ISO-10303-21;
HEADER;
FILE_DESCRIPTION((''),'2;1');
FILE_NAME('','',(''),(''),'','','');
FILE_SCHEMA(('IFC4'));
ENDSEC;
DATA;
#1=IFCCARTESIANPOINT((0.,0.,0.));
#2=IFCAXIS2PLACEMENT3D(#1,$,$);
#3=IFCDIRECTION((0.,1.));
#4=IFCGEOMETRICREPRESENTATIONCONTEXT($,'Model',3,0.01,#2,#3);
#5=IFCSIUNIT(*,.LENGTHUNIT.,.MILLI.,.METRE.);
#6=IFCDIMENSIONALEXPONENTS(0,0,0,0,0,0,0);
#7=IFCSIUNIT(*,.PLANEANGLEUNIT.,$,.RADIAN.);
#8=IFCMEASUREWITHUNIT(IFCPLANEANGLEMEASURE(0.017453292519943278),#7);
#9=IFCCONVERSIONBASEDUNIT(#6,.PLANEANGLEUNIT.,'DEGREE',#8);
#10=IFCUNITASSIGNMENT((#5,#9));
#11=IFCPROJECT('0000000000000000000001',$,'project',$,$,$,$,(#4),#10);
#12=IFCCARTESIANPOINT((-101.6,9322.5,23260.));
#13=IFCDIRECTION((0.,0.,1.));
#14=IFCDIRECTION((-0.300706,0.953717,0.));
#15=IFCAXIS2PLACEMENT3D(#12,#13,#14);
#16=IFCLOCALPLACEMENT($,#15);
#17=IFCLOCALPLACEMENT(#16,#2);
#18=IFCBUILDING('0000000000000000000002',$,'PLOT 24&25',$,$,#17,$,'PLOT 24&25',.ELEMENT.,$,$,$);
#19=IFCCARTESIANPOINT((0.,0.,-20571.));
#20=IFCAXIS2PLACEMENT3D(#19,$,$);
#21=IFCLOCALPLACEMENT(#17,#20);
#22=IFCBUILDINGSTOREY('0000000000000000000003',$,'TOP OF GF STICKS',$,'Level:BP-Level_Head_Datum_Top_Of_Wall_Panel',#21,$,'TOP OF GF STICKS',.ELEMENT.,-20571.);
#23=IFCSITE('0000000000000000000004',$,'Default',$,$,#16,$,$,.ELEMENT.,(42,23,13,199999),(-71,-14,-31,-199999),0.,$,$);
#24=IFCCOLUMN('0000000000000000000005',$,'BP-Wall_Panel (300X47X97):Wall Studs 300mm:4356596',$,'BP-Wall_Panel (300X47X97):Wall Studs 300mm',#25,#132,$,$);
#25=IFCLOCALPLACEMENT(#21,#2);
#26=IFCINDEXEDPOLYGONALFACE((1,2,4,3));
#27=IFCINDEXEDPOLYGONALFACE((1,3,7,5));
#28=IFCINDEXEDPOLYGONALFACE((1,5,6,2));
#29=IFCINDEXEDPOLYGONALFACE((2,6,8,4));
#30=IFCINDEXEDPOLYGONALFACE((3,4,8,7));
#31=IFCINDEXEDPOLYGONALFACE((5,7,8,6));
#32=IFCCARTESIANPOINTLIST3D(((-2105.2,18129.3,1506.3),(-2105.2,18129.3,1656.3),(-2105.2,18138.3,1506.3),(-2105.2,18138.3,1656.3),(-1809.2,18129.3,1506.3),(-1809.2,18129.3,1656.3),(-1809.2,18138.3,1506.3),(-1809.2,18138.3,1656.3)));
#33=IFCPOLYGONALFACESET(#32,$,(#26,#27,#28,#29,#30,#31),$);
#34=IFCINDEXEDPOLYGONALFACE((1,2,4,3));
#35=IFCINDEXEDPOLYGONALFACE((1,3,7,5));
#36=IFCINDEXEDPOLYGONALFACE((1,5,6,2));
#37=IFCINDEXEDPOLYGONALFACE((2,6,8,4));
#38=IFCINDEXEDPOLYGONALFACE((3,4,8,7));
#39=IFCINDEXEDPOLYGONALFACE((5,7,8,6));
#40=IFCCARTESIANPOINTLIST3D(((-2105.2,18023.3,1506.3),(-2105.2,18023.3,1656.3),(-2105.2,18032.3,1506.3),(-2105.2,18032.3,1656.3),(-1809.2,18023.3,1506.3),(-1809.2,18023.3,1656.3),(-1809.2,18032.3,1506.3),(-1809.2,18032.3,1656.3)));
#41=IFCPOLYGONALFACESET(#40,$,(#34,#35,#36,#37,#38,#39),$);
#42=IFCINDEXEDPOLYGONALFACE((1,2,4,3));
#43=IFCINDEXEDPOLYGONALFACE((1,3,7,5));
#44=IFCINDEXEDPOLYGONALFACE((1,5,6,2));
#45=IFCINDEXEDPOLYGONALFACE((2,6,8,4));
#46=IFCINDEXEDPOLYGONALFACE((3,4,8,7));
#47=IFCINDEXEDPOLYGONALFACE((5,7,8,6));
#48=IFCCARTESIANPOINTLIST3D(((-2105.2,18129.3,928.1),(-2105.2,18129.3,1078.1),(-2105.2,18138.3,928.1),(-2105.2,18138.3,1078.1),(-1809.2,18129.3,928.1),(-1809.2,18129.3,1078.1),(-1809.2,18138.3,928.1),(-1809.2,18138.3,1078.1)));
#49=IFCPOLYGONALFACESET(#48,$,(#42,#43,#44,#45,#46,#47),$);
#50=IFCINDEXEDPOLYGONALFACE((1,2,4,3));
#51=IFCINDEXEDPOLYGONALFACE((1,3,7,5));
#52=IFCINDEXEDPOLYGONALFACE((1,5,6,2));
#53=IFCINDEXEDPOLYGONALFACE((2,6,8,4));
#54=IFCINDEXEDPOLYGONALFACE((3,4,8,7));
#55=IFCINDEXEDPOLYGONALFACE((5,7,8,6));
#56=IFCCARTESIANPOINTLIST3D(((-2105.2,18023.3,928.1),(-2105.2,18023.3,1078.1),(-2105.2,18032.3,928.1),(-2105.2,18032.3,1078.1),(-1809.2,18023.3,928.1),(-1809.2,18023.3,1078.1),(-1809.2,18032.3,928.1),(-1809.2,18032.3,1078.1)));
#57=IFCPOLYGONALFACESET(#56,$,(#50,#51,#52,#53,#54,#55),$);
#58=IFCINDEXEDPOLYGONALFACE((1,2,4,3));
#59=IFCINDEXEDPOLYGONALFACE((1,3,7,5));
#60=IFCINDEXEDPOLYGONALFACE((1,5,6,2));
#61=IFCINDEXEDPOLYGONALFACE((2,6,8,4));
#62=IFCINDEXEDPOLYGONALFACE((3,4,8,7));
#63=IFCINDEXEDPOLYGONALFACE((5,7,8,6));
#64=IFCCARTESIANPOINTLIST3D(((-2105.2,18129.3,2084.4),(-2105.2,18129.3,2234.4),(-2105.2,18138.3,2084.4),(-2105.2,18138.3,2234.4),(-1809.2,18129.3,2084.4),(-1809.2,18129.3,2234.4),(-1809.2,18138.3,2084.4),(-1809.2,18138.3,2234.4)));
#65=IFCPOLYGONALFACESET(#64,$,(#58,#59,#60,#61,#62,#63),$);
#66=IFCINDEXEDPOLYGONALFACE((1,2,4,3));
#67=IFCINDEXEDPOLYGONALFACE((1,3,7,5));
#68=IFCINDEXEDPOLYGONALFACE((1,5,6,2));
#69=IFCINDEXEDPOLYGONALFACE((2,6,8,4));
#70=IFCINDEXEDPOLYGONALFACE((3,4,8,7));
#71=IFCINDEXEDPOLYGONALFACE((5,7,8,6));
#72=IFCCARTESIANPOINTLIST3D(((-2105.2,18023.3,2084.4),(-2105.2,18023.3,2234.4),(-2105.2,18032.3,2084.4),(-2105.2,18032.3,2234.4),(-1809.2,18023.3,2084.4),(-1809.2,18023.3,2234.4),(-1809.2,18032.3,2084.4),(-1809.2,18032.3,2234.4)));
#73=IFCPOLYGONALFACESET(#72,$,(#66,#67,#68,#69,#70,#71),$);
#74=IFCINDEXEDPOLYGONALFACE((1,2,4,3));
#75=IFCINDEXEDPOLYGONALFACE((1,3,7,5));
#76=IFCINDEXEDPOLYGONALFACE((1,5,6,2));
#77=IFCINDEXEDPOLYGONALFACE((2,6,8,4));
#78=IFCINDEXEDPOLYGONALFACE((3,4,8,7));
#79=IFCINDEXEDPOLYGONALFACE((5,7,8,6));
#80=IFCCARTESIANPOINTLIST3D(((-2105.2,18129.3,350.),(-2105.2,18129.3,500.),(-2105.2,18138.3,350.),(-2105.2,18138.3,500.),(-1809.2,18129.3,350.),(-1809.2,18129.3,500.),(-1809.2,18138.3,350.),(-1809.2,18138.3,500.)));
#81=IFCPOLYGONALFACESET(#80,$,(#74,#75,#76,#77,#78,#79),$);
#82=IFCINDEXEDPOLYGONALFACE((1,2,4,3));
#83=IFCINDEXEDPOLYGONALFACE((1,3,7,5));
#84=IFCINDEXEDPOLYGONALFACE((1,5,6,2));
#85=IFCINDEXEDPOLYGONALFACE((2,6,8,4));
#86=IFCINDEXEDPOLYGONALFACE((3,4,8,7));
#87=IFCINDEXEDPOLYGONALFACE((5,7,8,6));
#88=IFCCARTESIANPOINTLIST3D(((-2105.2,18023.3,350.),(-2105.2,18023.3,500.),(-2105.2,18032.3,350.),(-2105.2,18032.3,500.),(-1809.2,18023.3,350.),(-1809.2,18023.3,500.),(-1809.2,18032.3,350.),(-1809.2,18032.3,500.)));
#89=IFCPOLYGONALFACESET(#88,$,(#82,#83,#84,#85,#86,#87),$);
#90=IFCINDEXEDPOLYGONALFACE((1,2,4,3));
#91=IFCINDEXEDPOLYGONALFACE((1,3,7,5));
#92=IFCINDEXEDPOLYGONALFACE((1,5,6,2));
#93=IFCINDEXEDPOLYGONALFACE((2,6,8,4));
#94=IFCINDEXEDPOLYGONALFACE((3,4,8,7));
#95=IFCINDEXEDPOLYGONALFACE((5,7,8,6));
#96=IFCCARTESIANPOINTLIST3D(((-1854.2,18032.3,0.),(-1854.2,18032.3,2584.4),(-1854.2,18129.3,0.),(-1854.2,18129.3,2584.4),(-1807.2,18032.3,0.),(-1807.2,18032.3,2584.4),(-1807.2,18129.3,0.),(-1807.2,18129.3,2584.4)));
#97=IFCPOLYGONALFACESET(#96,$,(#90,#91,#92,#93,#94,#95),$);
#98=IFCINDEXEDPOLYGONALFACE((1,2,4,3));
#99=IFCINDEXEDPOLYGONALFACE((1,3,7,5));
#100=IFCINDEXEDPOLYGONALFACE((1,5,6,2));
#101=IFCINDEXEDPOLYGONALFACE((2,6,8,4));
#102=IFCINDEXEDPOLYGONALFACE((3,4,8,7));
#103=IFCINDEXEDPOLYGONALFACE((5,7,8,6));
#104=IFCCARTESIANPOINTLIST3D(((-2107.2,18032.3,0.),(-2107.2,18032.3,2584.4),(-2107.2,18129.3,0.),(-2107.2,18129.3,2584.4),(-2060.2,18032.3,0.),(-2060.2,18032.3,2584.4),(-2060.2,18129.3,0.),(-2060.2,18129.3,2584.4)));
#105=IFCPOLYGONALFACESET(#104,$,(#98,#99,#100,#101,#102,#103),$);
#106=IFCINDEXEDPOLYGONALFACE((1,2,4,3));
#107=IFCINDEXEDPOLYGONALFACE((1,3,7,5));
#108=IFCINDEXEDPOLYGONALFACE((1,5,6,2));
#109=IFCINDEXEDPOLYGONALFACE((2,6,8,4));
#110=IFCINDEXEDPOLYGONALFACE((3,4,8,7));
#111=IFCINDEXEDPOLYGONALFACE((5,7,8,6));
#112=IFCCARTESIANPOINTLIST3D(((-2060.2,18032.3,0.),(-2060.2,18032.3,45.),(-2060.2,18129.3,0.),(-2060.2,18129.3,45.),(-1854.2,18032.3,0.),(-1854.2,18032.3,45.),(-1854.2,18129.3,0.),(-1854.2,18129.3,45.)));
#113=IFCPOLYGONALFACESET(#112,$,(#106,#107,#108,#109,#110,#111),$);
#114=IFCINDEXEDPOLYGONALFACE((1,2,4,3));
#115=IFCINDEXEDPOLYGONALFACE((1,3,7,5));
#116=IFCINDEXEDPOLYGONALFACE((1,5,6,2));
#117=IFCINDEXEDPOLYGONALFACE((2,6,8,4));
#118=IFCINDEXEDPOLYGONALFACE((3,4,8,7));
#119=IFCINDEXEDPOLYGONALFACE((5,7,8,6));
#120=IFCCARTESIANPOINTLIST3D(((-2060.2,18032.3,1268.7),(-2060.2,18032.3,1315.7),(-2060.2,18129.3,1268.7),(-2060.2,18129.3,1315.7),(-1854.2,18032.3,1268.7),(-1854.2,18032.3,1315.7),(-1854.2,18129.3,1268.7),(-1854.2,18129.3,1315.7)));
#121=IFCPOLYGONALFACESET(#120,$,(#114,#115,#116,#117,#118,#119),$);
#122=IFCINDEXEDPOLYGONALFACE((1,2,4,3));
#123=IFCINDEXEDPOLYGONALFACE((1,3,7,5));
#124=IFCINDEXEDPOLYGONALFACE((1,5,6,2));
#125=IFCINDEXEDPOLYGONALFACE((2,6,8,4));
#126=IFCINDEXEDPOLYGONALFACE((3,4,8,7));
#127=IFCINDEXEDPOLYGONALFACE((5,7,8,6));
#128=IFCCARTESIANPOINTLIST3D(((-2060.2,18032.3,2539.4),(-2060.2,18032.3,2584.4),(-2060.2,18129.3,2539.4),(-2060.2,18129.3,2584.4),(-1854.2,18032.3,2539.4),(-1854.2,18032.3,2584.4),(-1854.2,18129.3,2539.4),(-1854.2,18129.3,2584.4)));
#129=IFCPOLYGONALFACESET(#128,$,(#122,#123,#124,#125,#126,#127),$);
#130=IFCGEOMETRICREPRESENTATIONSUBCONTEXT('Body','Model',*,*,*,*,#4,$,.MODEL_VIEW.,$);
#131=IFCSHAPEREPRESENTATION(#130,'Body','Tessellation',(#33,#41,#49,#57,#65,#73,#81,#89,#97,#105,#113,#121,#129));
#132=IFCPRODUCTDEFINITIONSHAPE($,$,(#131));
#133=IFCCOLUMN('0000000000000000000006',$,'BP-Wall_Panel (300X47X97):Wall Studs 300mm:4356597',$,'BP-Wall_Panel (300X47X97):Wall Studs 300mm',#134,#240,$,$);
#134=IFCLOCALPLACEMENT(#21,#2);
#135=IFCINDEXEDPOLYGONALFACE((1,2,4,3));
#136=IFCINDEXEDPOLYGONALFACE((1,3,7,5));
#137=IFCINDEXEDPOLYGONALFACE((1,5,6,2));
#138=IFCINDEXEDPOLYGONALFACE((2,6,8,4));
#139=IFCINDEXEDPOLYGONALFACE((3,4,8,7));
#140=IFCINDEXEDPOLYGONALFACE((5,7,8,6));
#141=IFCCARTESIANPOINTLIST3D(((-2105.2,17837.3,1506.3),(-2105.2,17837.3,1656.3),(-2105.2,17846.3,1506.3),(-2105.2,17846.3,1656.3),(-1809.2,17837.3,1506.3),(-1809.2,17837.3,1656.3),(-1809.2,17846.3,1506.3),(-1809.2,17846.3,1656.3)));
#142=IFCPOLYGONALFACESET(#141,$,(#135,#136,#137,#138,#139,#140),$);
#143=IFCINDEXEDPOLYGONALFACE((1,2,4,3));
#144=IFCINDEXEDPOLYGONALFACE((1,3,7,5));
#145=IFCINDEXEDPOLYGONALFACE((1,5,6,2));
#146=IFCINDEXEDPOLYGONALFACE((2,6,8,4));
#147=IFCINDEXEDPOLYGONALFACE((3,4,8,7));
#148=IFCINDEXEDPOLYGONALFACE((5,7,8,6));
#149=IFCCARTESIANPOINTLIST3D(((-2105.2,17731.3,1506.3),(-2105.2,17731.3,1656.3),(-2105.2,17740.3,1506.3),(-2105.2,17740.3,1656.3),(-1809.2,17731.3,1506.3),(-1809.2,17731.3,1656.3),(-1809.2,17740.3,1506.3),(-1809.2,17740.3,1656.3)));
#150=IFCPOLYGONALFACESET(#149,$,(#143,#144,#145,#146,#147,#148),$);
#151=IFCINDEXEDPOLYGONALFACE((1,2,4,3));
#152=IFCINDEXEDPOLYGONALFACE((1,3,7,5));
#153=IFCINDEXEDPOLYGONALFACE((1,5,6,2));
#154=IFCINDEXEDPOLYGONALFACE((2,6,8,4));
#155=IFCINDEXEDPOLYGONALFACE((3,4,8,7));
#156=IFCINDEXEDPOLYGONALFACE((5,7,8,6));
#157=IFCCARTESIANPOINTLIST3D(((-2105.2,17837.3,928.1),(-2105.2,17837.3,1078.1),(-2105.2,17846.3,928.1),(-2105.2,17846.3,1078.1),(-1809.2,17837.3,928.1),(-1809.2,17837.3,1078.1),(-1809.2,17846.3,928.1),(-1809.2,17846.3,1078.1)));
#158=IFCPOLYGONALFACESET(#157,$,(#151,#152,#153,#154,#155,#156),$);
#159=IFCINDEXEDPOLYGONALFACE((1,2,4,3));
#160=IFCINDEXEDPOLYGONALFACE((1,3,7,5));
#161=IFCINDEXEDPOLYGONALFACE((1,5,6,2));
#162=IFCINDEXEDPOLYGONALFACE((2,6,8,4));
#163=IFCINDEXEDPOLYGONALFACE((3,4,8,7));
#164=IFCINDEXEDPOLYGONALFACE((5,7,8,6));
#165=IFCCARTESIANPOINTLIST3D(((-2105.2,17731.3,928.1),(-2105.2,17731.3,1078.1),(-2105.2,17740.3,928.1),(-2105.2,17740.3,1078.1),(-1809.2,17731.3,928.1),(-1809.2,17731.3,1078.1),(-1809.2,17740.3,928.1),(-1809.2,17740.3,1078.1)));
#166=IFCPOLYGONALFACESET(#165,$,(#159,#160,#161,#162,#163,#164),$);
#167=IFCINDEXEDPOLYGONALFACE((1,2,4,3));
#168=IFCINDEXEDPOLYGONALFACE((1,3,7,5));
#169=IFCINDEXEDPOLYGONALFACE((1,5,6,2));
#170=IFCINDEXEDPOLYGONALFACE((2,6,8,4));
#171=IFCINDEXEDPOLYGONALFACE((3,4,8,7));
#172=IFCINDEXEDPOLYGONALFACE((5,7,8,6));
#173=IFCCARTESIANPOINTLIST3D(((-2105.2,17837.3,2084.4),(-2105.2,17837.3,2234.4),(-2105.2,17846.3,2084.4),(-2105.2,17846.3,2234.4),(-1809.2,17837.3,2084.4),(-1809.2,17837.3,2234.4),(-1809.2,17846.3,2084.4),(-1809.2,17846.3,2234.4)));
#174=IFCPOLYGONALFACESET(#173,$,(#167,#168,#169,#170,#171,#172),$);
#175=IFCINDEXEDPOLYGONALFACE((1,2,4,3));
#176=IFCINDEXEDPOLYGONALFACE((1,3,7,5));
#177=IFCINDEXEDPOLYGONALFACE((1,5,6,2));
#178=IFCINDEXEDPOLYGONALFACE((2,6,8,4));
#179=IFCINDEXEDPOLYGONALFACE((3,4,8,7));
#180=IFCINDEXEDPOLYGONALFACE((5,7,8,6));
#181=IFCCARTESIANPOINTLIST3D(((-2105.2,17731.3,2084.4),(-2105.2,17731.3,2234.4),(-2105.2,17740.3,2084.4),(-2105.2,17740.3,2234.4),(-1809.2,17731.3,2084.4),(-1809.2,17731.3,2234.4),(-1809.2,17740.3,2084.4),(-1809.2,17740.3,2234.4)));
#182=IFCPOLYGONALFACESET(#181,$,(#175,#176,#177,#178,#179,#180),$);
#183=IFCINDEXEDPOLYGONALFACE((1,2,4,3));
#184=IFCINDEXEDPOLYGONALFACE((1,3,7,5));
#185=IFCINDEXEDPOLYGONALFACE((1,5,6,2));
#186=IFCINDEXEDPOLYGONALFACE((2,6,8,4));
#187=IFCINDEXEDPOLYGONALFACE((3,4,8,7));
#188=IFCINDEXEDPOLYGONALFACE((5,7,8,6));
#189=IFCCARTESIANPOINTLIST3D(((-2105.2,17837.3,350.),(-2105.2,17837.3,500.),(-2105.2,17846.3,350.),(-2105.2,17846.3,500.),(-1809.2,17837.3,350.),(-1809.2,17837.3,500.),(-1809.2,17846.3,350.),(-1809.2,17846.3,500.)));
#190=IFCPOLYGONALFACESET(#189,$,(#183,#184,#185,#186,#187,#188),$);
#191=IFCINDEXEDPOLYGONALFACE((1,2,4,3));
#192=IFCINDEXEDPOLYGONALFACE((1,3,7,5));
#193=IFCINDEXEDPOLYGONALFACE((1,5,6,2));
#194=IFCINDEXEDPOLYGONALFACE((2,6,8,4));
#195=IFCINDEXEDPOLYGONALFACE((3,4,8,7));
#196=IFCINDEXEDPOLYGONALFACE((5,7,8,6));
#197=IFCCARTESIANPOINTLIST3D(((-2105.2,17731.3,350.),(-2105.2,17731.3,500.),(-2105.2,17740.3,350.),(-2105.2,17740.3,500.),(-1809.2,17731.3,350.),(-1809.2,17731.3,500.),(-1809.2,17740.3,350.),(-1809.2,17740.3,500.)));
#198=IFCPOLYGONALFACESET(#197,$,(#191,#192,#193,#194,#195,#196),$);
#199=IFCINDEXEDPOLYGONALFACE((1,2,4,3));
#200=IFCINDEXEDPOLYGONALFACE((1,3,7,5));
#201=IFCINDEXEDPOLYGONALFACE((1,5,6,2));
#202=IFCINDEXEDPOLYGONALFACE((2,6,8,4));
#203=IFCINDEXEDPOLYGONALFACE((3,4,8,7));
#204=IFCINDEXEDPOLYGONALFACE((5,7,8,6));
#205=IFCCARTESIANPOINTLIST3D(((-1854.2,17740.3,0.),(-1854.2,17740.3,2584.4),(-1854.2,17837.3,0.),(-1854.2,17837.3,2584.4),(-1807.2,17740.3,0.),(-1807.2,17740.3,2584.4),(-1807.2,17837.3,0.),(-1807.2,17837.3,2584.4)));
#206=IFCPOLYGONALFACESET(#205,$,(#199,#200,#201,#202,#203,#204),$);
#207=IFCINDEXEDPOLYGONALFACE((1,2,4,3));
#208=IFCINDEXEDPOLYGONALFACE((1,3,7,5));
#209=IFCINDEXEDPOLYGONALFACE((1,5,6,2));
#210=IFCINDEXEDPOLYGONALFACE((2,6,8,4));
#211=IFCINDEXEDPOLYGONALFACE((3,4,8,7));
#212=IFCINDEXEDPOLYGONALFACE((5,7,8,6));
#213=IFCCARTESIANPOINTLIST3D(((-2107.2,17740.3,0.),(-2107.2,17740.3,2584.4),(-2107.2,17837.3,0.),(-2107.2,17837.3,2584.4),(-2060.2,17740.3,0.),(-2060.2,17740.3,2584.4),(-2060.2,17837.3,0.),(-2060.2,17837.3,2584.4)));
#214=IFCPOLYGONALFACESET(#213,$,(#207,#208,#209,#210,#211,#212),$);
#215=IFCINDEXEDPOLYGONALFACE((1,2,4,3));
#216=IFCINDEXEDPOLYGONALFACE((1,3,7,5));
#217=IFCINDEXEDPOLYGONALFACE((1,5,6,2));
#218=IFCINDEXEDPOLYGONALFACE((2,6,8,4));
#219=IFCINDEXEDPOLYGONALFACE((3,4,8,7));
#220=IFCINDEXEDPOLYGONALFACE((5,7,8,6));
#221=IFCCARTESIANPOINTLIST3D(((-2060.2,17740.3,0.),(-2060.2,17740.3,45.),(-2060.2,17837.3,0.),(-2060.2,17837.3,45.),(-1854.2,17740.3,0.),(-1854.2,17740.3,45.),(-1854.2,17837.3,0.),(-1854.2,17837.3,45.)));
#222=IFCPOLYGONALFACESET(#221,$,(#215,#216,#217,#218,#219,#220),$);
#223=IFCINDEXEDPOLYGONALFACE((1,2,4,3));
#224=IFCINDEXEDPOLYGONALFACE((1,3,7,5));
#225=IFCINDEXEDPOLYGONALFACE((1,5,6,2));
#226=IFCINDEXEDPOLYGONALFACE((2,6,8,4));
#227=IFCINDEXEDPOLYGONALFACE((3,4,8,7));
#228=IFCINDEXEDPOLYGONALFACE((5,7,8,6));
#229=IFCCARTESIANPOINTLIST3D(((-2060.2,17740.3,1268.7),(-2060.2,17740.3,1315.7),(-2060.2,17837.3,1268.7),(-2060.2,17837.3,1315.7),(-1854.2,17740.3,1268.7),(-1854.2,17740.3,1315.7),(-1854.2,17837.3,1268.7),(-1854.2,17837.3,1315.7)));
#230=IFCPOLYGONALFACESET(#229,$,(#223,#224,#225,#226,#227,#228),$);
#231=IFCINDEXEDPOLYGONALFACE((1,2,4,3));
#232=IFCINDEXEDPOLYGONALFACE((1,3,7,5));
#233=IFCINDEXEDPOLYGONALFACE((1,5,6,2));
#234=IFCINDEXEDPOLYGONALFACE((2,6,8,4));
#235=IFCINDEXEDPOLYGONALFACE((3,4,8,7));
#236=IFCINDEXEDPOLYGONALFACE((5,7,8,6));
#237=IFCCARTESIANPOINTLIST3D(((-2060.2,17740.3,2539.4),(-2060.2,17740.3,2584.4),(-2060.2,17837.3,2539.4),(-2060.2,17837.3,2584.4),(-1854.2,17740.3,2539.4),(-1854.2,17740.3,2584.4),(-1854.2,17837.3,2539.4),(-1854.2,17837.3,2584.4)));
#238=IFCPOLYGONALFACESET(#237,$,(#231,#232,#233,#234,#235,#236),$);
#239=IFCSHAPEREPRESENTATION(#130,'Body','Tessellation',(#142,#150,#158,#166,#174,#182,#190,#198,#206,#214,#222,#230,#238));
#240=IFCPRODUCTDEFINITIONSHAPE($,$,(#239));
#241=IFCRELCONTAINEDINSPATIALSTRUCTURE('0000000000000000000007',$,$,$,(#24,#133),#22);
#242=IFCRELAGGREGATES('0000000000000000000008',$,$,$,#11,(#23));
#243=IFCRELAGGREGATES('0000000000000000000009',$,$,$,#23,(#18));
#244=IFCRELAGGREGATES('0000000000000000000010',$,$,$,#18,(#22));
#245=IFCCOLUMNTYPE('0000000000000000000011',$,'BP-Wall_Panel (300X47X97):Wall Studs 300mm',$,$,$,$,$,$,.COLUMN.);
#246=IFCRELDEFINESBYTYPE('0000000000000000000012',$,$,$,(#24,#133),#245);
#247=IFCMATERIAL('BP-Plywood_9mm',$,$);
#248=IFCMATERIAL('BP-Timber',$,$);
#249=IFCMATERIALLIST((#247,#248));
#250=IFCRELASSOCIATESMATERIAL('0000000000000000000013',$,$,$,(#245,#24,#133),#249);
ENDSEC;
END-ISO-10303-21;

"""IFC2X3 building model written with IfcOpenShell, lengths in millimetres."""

from ifc_helpers import new_model, entity, si_unit, converted_unit, direction, frame, frame_2d, origin, origin_2d_with_axis, place, context, subcontext, project, spatial, rectangle, extrude, source, transform, mapped, material, material_list, type_object, type_shapes, element, save


model = new_model("IFC2X3")

# Units and contexts
model_context = context("Model", 3, precision=0.01, world=origin(), true_north=direction((0.0, 1.0)))
body_context = subcontext(model_context, "Body", "Model", "MODEL_VIEW")
ifc_project = project(units=[si_unit("LENGTHUNIT", "METRE", prefix="MILLI"), converted_unit("PLANEANGLEUNIT", "DEGREE", entity("IfcPlaneAngleMeasure", 0.017453292519943278), si_unit("PLANEANGLEUNIT", "RADIAN"), dimensions=[0, 0, 0, 0, 0, 0, 0])], contexts=[model_context])

# Site, building, storey
site_placement = place(None, frame((-101.6, 9322.5, 23260.0), z_axis=(0.0, 0.0, 1.0), x_axis=(-0.300706, 0.953717, 0.0)))
site = spatial("IfcSite", under=ifc_project, at=site_placement, Name="Default", CompositionType="ELEMENT", RefLatitude=(42, 23, 13, 199999), RefLongitude=(-71, -14, -31, -199999), RefElevation=0.0)
building_placement = place(site_placement, origin())
building = spatial("IfcBuilding", under=site, at=building_placement, Name="PLOT 24&25", LongName="PLOT 24&25", CompositionType="ELEMENT")
storey_placement = place(building_placement, frame((0.0, 0.0, -20571.0)))
storey = spatial("IfcBuildingStorey", under=building, at=storey_placement, Name="TOP OF GF STICKS", ObjectType="Level:BP-Level_Head_Datum_Top_Of_Wall_Panel", LongName="TOP OF GF STICKS", CompositionType="ELEMENT", Elevation=-20571.0)

# Columns
ifc_material_1 = material(Name="BP-Plywood_9mm")
ifc_material_2 = material(Name="BP-Timber")
ifc_material_list = material_list([ifc_material_1, ifc_material_2])
column_type_1 = type_object("IfcColumnType", Name="BP-Wall_Panel (300X47X97):Wall Studs 300mm", PredefinedType="COLUMN", material=ifc_material_list)
shared_shape_1 = source(origin(), body_context, "Body", "SweptSolid", [
    extrude(rectangle(XDim=296.0, YDim=9.0, at=origin_2d_with_axis()), frame((53.0, 0.0, -19064.7), z_axis=(0.0, 0.0, 1.0), x_axis=(0.0, -1.0, 0.0)), (0.0, 0.0, 1.0), 150.0),
    extrude(rectangle(XDim=9.0, YDim=296.0, at=origin_2d_with_axis()), frame((-53.0, 0.0, -19064.7), z_axis=(0.0, 0.0, 1.0), x_axis=(-1.0, 0.0, 0.0)), (0.0, 0.0, 1.0), 150.0),
    extrude(rectangle(XDim=296.0, YDim=9.0, at=origin_2d_with_axis()), frame((53.0, 0.0, -19642.9), z_axis=(0.0, 0.0, 1.0), x_axis=(0.0, -1.0, 0.0)), (0.0, 0.0, 1.0), 150.0),
    extrude(rectangle(XDim=9.0, YDim=296.0, at=origin_2d_with_axis()), frame((-53.0, 0.0, -19642.9), z_axis=(0.0, 0.0, 1.0), x_axis=(-1.0, 0.0, 0.0)), (0.0, 0.0, 1.0), 150.0),
    extrude(rectangle(XDim=296.0, YDim=9.0, at=origin_2d_with_axis()), frame((53.0, 0.0, -18486.6), z_axis=(0.0, 0.0, 1.0), x_axis=(0.0, -1.0, 0.0)), (0.0, 0.0, 1.0), 150.0),
    extrude(rectangle(XDim=9.0, YDim=296.0, at=origin_2d_with_axis()), frame((-53.0, 0.0, -18486.6), z_axis=(0.0, 0.0, 1.0), x_axis=(-1.0, 0.0, 0.0)), (0.0, 0.0, 1.0), 150.0),
    extrude(rectangle(XDim=296.0, YDim=9.0, at=origin_2d_with_axis()), frame((53.0, 0.0, -20221.0), z_axis=(0.0, 0.0, 1.0), x_axis=(0.0, -1.0, 0.0)), (0.0, 0.0, 1.0), 150.0),
    extrude(rectangle(XDim=9.0, YDim=296.0, at=origin_2d_with_axis()), frame((-53.0, 0.0, -20221.0), z_axis=(0.0, 0.0, 1.0), x_axis=(-1.0, 0.0, 0.0)), (0.0, 0.0, 1.0), 150.0),
    extrude(rectangle(XDim=97.0, YDim=47.0, at=origin_2d_with_axis()), frame((0.0, -126.5, -20571.0), z_axis=(0.0, 0.0, 1.0), x_axis=(-1.0, 0.0, 0.0)), (0.0, 0.0, 1.0), 2584.4),
    extrude(rectangle(XDim=97.0, YDim=47.0, at=frame_2d((0.0, 0.0), x_axis=(1.0, 0.0))), frame((0.0, 126.5, -20571.0), z_axis=(0.0, 0.0, 1.0), x_axis=(-1.0, 0.0, 0.0)), (0.0, 0.0, 1.0), 2584.4),
    extrude(rectangle(XDim=206.0, YDim=97.0, at=origin_2d_with_axis()), frame((0.0, 0.0, -20571.0), z_axis=(0.0, 0.0, 1.0), x_axis=(0.0, -1.0, 0.0)), (0.0, 0.0, 1.0), 45.0),
    extrude(rectangle(XDim=206.0, YDim=97.0, at=origin_2d_with_axis()), frame((0.0, 0.0, -19302.3), z_axis=(0.0, 0.0, 1.0), x_axis=(0.0, -1.0, 0.0)), (0.0, 0.0, 1.0), 47.0),
    extrude(rectangle(XDim=206.0, YDim=97.0, at=origin_2d_with_axis()), frame((0.0, 0.0, -18031.6), z_axis=(0.0, 0.0, 1.0), x_axis=(0.0, -1.0, 0.0)), (0.0, 0.0, 1.0), 45.0),
])
type_shapes(column_type_1, [shared_shape_1])
for number, where, z_axis, x_axis, name in (
    (1, (-1957.2, 18080.8, 20571.0), (0.0, 0.0, 1.0), (0.0, 1.0, 0.0), "BP-Wall_Panel (300X47X97):Wall Studs 300mm:4356596"),
    (2, (-1957.2, 17788.8, 20571.0), (0.0, 0.0, 1.0), (0.0, 1.0, 0.0), "BP-Wall_Panel (300X47X97):Wall Studs 300mm:4356597"),
):
    element("IfcColumn", number, at=place(storey_placement, frame(where, z_axis=z_axis, x_axis=x_axis)), inside=storey, type_object=column_type_1, material=ifc_material_list, Name=name, ObjectType="BP-Wall_Panel (300X47X97):Wall Studs 300mm", context=body_context, shape_type="MappedRepresentation", body=[
        mapped(shared_shape_1, transform((0.0, 0.0, 0.0), scale=1.0)),
    ])

save(model, "model.ifc")
